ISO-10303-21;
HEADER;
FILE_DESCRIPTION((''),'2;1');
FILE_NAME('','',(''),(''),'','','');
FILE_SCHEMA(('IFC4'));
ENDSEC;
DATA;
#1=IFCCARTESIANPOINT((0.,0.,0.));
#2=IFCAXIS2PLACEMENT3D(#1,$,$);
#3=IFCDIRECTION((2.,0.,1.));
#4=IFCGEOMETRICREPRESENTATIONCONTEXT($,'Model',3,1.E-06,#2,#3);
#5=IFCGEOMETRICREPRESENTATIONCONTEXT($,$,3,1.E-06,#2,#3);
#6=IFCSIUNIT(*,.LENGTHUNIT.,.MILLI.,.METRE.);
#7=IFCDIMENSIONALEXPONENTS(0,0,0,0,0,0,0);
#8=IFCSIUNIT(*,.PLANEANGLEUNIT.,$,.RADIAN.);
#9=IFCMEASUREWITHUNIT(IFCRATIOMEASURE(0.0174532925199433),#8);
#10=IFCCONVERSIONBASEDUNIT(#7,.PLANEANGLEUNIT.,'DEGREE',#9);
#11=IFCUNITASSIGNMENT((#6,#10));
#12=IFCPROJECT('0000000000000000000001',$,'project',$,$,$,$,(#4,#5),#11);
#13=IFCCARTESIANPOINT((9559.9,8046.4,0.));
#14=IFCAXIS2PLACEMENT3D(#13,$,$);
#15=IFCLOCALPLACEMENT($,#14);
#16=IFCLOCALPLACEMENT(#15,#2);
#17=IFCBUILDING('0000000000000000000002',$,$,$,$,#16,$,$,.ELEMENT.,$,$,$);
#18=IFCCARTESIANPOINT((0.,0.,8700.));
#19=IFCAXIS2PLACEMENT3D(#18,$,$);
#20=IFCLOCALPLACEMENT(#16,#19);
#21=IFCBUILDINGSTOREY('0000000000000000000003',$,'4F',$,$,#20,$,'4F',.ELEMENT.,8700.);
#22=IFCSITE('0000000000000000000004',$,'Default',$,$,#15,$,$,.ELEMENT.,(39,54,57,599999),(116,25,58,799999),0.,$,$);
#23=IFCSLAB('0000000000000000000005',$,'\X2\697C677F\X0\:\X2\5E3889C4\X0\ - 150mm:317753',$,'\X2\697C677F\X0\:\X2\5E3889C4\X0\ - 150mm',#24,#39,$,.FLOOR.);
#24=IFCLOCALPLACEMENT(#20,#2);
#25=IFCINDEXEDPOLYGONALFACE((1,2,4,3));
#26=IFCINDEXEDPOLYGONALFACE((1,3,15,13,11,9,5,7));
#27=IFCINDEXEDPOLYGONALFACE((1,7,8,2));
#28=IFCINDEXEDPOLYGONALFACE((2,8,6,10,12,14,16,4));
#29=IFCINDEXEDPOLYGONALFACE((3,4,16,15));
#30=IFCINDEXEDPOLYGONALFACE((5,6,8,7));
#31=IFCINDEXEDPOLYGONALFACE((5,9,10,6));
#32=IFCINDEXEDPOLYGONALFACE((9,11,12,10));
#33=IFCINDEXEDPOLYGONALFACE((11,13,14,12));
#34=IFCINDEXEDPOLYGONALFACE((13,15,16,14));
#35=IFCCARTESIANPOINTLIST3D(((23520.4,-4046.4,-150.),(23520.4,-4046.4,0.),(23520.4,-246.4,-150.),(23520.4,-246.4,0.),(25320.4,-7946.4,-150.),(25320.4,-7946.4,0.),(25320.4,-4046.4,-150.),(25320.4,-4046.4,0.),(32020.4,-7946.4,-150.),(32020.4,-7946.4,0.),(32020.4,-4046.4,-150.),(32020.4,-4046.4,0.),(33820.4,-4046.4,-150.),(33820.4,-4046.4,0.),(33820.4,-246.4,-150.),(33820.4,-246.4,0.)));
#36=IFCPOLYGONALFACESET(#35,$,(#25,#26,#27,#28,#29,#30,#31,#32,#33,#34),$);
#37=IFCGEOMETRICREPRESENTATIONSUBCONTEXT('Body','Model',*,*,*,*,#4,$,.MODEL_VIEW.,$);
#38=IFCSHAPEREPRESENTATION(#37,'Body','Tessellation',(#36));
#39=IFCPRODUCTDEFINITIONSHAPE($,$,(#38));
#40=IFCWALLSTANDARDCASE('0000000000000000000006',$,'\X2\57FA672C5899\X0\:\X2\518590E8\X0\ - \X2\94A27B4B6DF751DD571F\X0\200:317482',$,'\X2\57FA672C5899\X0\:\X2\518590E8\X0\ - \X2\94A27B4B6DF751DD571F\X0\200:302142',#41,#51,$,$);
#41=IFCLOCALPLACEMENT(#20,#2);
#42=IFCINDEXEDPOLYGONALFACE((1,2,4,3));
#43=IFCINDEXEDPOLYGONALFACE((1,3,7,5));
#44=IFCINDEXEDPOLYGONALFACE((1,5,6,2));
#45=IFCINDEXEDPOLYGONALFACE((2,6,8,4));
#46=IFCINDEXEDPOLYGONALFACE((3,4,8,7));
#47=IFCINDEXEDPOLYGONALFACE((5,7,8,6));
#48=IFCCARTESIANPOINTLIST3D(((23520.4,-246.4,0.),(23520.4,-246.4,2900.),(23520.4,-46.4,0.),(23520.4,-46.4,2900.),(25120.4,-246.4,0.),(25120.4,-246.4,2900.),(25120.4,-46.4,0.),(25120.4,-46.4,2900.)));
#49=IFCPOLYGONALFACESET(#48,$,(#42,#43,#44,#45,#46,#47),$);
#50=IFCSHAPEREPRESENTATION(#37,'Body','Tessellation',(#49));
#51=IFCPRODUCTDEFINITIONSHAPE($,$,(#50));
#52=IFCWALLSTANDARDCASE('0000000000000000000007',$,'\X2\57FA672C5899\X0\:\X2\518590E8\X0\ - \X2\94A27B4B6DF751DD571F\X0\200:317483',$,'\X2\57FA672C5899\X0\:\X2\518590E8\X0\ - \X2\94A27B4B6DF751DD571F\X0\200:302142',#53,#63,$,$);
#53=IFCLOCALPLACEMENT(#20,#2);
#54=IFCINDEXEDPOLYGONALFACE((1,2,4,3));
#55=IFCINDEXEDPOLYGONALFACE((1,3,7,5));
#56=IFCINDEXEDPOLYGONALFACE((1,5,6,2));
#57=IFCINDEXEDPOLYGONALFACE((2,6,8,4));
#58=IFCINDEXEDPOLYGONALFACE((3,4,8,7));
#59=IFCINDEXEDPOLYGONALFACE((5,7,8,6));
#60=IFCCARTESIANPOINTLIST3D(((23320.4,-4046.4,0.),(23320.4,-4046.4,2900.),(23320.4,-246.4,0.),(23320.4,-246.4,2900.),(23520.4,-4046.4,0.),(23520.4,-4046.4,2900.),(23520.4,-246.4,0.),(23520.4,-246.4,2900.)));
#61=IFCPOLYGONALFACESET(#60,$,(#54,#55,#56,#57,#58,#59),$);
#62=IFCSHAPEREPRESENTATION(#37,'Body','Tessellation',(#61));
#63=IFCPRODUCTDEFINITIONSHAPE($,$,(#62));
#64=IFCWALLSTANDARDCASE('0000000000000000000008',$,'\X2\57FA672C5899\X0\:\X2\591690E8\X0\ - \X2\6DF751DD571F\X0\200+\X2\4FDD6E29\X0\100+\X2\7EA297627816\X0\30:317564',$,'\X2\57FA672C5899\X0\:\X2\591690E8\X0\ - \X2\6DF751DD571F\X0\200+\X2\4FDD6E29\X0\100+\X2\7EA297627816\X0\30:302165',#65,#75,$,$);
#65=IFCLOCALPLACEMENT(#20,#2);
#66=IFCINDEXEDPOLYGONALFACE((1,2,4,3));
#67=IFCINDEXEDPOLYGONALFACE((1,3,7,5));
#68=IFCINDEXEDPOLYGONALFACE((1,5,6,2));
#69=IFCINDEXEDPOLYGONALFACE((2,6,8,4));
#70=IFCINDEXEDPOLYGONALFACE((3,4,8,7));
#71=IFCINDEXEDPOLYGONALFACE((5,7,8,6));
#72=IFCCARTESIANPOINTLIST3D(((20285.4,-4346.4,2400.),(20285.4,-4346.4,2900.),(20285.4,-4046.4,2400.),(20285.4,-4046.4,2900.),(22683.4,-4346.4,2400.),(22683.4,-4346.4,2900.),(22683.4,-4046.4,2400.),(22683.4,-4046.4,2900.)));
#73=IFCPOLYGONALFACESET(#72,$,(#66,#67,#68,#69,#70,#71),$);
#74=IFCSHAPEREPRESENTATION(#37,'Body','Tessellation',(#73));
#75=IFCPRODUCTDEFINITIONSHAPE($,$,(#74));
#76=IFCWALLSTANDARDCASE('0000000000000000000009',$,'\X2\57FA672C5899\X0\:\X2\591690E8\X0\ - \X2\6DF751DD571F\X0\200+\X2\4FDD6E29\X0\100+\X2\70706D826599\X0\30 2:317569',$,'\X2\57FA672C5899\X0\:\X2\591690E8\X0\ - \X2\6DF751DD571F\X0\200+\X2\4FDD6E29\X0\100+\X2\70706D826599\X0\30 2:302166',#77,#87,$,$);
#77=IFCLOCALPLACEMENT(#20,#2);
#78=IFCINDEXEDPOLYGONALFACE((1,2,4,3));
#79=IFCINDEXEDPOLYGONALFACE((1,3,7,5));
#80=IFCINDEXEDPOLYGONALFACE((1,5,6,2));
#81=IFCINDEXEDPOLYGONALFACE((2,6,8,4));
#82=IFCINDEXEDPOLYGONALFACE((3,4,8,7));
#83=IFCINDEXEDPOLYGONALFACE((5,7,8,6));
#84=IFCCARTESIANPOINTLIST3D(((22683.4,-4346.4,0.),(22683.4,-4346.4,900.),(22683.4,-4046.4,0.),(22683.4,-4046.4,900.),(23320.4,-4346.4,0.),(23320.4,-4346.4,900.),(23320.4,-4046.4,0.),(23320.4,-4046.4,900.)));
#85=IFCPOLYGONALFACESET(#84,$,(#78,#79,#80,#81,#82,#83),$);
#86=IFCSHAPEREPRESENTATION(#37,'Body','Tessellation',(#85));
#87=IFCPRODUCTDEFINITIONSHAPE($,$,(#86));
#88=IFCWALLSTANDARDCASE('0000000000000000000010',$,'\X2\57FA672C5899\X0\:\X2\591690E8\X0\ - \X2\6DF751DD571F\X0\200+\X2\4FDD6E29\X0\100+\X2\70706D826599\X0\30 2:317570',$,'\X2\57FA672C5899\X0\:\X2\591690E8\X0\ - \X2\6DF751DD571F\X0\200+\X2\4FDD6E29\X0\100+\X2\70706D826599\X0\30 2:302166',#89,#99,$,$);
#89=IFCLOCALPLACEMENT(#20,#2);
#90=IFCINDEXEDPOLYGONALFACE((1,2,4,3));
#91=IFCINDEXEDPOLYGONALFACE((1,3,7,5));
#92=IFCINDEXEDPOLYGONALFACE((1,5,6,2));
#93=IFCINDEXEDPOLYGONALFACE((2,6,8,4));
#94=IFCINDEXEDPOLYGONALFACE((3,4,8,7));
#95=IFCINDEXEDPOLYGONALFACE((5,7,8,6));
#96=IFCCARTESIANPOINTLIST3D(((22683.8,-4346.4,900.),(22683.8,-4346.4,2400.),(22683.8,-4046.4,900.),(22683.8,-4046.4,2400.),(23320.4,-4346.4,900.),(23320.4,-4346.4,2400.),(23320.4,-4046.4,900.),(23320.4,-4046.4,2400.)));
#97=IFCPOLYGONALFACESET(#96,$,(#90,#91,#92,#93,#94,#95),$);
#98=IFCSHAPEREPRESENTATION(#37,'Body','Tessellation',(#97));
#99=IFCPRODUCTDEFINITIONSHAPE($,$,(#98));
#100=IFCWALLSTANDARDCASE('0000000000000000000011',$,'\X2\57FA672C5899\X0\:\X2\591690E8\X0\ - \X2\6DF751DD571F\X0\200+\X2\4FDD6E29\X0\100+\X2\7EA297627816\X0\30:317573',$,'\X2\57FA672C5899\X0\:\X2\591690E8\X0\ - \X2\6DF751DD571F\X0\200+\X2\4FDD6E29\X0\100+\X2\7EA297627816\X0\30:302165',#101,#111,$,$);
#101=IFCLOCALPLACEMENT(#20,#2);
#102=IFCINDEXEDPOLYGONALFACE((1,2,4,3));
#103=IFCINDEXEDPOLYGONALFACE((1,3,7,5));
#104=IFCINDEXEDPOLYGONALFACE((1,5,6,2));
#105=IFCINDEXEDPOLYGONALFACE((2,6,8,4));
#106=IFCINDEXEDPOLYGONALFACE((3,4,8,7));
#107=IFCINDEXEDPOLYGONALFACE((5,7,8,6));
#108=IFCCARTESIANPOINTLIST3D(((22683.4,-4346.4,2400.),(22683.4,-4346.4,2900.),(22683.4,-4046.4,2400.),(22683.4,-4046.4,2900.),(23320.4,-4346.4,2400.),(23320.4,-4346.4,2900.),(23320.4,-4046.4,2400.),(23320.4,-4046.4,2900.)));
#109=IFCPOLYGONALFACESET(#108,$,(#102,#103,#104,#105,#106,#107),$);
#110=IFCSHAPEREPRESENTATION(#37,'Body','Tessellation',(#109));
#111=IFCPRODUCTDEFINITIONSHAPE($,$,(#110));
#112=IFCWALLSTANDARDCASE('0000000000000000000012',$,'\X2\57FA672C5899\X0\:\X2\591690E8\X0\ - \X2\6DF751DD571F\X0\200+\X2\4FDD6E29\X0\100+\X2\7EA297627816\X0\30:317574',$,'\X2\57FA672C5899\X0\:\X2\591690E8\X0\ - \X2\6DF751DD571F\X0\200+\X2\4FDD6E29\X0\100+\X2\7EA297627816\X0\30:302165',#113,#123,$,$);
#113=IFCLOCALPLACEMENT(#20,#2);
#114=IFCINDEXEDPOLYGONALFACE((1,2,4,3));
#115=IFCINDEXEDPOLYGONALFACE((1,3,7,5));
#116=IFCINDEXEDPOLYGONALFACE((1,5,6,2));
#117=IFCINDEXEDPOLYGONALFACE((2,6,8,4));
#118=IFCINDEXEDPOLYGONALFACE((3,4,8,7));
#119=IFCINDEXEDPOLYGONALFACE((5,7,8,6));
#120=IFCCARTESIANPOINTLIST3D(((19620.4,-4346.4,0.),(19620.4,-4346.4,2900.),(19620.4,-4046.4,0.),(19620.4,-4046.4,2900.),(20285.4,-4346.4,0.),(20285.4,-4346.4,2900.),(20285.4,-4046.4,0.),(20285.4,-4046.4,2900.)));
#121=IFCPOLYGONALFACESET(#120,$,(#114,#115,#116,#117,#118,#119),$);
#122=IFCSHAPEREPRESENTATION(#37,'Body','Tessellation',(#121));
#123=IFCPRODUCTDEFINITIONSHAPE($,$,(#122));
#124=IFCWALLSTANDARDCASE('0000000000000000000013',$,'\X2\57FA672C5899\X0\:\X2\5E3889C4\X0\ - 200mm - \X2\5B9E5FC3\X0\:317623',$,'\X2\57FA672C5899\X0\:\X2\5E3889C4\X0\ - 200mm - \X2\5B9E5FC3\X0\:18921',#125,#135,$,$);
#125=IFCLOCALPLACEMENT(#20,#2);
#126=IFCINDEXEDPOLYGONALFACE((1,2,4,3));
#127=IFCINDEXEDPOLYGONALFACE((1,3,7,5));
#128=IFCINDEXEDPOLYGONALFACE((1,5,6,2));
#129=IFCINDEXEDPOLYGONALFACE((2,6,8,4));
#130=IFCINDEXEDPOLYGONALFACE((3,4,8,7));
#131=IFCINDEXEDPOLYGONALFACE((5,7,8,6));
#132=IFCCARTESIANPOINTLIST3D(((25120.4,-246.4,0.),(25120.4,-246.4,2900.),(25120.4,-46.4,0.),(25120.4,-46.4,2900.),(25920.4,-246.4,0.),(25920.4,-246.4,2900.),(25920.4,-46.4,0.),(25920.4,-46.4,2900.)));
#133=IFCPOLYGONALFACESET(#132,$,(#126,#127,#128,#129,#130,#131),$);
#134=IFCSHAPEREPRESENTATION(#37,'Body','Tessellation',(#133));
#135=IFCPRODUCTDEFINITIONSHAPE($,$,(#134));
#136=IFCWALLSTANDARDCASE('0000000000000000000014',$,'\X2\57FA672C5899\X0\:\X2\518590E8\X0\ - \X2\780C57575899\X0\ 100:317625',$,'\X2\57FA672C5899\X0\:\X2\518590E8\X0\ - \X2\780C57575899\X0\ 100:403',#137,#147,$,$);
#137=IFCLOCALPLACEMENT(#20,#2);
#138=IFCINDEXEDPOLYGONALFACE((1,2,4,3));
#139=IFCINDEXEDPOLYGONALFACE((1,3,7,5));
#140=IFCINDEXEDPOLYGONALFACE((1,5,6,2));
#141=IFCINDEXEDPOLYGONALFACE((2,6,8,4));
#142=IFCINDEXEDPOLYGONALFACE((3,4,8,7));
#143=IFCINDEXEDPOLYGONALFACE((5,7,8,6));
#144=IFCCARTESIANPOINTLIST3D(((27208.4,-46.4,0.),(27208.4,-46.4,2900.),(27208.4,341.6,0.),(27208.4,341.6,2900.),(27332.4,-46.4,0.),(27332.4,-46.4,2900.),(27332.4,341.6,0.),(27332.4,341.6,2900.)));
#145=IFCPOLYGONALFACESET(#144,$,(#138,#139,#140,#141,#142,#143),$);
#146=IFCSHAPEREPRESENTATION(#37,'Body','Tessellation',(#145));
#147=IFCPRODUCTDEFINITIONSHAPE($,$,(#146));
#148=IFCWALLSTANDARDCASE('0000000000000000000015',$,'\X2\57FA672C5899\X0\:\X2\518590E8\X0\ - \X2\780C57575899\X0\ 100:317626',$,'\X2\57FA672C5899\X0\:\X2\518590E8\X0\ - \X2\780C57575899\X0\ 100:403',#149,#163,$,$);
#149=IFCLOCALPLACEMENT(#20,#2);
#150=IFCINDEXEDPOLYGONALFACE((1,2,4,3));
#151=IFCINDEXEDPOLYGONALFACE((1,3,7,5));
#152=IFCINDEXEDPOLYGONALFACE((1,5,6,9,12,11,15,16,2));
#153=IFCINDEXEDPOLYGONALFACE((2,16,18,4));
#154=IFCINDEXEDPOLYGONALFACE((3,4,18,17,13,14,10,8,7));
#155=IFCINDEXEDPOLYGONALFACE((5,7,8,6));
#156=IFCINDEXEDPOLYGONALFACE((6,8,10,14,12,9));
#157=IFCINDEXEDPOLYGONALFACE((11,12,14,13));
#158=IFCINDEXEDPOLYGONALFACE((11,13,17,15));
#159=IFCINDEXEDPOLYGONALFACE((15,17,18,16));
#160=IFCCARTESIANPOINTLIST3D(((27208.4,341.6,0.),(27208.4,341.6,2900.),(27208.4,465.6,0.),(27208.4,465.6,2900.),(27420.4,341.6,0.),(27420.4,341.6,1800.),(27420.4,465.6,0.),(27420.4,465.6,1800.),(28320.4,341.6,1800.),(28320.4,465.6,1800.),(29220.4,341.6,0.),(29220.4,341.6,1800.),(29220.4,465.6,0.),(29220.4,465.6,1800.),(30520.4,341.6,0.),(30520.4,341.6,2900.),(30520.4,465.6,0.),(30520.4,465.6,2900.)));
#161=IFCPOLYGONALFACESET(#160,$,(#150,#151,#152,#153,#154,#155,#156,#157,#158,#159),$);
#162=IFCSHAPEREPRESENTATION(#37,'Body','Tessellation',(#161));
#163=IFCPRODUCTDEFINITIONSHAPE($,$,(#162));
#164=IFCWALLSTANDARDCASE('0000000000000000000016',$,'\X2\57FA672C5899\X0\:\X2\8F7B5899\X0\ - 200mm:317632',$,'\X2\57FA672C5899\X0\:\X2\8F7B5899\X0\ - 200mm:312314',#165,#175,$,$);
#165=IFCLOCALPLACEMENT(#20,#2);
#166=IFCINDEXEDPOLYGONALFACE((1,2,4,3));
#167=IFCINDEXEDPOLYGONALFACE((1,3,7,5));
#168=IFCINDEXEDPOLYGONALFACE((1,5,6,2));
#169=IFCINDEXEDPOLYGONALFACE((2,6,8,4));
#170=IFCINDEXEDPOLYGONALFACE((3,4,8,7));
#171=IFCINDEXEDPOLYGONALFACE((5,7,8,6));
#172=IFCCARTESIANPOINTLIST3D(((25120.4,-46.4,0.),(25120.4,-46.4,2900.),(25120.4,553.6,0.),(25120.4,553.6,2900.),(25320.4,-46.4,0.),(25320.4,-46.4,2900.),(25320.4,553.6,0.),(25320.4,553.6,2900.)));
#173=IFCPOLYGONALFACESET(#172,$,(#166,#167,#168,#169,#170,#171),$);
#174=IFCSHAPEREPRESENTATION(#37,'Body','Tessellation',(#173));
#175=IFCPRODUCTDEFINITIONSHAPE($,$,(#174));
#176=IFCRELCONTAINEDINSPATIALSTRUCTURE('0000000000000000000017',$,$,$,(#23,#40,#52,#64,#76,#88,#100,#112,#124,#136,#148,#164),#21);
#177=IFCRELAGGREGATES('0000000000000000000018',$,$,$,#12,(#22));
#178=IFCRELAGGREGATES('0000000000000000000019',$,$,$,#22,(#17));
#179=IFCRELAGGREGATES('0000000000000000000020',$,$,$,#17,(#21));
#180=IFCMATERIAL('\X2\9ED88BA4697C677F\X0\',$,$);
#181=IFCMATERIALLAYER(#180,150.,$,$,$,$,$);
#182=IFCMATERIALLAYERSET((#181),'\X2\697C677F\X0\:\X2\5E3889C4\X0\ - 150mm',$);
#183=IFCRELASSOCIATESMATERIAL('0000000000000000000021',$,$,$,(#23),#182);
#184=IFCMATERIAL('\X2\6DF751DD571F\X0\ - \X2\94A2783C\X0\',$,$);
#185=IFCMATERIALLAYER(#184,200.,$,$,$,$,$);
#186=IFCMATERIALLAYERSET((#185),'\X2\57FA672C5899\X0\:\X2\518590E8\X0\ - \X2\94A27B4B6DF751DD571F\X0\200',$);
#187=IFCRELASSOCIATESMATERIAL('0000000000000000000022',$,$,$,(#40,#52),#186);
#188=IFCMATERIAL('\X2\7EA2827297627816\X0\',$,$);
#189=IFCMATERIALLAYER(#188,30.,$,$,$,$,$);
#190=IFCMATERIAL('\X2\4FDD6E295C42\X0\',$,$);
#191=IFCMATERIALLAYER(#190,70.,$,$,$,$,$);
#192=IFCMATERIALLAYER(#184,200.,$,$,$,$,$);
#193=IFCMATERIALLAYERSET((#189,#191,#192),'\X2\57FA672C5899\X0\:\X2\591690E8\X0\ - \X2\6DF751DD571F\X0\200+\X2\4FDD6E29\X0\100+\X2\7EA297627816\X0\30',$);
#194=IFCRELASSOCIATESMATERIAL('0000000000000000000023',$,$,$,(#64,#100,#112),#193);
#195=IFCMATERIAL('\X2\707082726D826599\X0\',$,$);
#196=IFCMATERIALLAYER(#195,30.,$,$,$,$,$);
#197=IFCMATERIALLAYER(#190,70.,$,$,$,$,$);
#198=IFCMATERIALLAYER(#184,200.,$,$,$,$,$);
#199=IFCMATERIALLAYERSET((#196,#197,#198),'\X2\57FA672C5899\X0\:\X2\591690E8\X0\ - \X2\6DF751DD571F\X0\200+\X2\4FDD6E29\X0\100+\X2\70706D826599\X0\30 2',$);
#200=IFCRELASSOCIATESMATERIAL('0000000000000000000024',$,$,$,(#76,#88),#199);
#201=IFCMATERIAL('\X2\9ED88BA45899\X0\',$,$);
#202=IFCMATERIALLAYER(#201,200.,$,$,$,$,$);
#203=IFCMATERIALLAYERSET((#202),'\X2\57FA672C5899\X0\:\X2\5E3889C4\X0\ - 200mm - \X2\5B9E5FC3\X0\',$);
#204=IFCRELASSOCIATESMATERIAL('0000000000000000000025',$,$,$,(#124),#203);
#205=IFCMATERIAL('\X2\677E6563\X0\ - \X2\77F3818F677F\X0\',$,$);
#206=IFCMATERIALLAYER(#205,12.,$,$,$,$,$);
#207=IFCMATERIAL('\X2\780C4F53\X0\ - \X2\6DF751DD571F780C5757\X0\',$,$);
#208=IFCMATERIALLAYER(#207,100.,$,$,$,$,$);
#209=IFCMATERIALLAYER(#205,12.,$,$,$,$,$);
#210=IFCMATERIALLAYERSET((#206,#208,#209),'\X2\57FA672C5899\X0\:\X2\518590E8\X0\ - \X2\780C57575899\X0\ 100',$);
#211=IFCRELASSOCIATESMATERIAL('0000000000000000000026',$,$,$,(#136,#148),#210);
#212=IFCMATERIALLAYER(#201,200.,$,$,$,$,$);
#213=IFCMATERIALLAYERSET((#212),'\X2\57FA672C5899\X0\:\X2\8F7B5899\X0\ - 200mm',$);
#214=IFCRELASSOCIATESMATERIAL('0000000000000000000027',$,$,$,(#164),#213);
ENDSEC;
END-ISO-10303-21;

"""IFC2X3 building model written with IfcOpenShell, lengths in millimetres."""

from ifc_helpers import new_model, entity, si_unit, converted_unit, direction, frame, frame_2d, origin, place, context, subcontext, project, spatial, polyline, rectangle, outline, extrude, material, layer, layer_set, layer_usage, element, save


model = new_model("IFC2X3")

# Units and contexts
model_context = context("Model", 3, precision=1e-06, world=origin(), true_north=direction((2.0, 0.0, 1.0)))
context_of_model = context(None, 3, precision=1e-06, world=origin(), true_north=direction((2.0, 0.0, 1.0)))
body_context = subcontext(model_context, "Body", "Model", "MODEL_VIEW")
ifc_project = project(units=[si_unit("LENGTHUNIT", "METRE", prefix="MILLI"), converted_unit("PLANEANGLEUNIT", "DEGREE", entity("IfcRatioMeasure", 0.0174532925199433), si_unit("PLANEANGLEUNIT", "RADIAN"), dimensions=[0, 0, 0, 0, 0, 0, 0])], contexts=[model_context, context_of_model])

# Site, building, storey
site_placement = place(None, frame((9559.9, 8046.4, 0.0)))
site = spatial("IfcSite", under=ifc_project, at=site_placement, Name="Default", CompositionType="ELEMENT", RefLatitude=(39, 54, 57, 599999), RefLongitude=(116, 25, 58, 799999), RefElevation=0.0)
building_placement = place(site_placement, origin())
building = spatial("IfcBuilding", under=site, at=building_placement, CompositionType="ELEMENT")
storey_placement = place(building_placement, frame((0.0, 0.0, 8700.0)))
storey = spatial("IfcBuildingStorey", under=building, at=storey_placement, Name="4F", LongName="4F", CompositionType="ELEMENT", Elevation=8700.0)

# Slab
ifc_material_1 = material(Name="默认楼板")
ifc_layer_1 = layer(ifc_material_1, 150.0)
ifc_layer_set_1 = layer_set([ifc_layer_1], Name="楼板:常规 - 150mm")
ifc_layer_usage_1 = layer_usage(ifc_layer_set_1, "AXIS3", "POSITIVE", 0.0)
slab_placement = place(storey_placement, frame((23520.4, -7946.4, -150.0)))
element("IfcSlab", 1, at=slab_placement, inside=storey, material=ifc_layer_usage_1, Name="楼板:常规 - 150mm:317753", ObjectType="楼板:常规 - 150mm", PredefinedType="FLOOR", context=body_context, shape_type="SweptSolid", body=[
    extrude(outline(polyline([(-5150.0, 50.0), (-3350.0, 50.0), (-3350.0, -3850.0), (3350.0, -3850.0), (3350.0, 50.0), (5150.0, 50.0), (5150.0, 3850.0), (-5150.0, 3850.0), (-5150.0, 50.0)])), frame((5150.0, 3850.0, 150.0), z_axis=(0.0, 0.0, -1.0), x_axis=(-1.0, 0.0, 0.0)), (0.0, 0.0, 1.0), 150.0),
])

# Walls
ifc_material_2 = material(Name="混凝土 - 钢砼")
ifc_layer_2 = layer(ifc_material_2, 200.0)
ifc_layer_set_2 = layer_set([ifc_layer_2], Name="基本墙:内部 - 钢筋混凝土200")
ifc_layer_usage_2 = layer_usage(ifc_layer_set_2, "AXIS2", "NEGATIVE", 100.0)
wall_1_placement = place(storey_placement, frame((25120.4, -146.4, 0.0), z_axis=(0.0, 0.0, 1.0), x_axis=(-1.0, 0.0, 0.0)))
element("IfcWallStandardCase", 2, at=wall_1_placement, inside=storey, material=ifc_layer_usage_2, Name="基本墙:内部 - 钢筋混凝土200:317482", ObjectType="基本墙:内部 - 钢筋混凝土200:302142", context=body_context, shape_type="SweptSolid", body=[
    extrude(rectangle(XDim=1600.0, YDim=200.0, at=frame_2d((800.0, 0.0), x_axis=(-1.0, 0.0))), origin(), (0.0, 0.0, 1.0), 2900.0),
])
ifc_layer_usage_3 = layer_usage(ifc_layer_set_2, "AXIS2", "NEGATIVE", 100.0)
wall_2_placement = place(storey_placement, frame((23420.4, -4046.4, 0.0), z_axis=(0.0, 0.0, 1.0), x_axis=(0.0, 1.0, 0.0)))
element("IfcWallStandardCase", 3, at=wall_2_placement, inside=storey, material=ifc_layer_usage_3, Name="基本墙:内部 - 钢筋混凝土200:317483", ObjectType="基本墙:内部 - 钢筋混凝土200:302142", context=body_context, shape_type="SweptSolid", body=[
    extrude(rectangle(XDim=3800.0, YDim=200.0, at=frame_2d((1900.0, 0.0), x_axis=(-1.0, 0.0))), origin(), (0.0, 0.0, 1.0), 2900.0),
])
ifc_material_3 = material(Name="红色面砖")
ifc_layer_3 = layer(ifc_material_3, 30.0)
ifc_material_4 = material(Name="保温层")
ifc_layer_4 = layer(ifc_material_4, 70.0)
ifc_layer_5 = layer(ifc_material_2, 200.0)
ifc_layer_set_3 = layer_set([ifc_layer_3, ifc_layer_4, ifc_layer_5], Name="基本墙:外部 - 混凝土200+保温100+红面砖30")
ifc_layer_usage_4 = layer_usage(ifc_layer_set_3, "AXIS2", "POSITIVE", -150.0)
wall_3_placement = place(storey_placement, frame((20285.4, -4196.4, 2400.0)))
element("IfcWallStandardCase", 4, at=wall_3_placement, inside=storey, material=ifc_layer_usage_4, Name="基本墙:外部 - 混凝土200+保温100+红面砖30:317564", ObjectType="基本墙:外部 - 混凝土200+保温100+红面砖30:302165", context=body_context, shape_type="SweptSolid", body=[
    extrude(rectangle(XDim=2398.1, YDim=300.0, at=frame_2d((1199.0, 0.0), x_axis=(-1.0, 0.0))), origin(), (0.0, 0.0, 1.0), 500.0),
])

# Walls
ifc_material_5 = material(Name="灰色涂料")
ifc_layer_6 = layer(ifc_material_5, 30.0)
ifc_layer_7 = layer(ifc_material_4, 70.0)
ifc_layer_8 = layer(ifc_material_2, 200.0)
ifc_layer_set_4 = layer_set([ifc_layer_6, ifc_layer_7, ifc_layer_8], Name="基本墙:外部 - 混凝土200+保温100+灰涂料30 2")
ifc_layer_usage_5 = layer_usage(ifc_layer_set_4, "AXIS2", "POSITIVE", -150.0)
wall_4_placement = place(storey_placement, frame((22683.4, -4196.4, 0.0)))
element("IfcWallStandardCase", 5, at=wall_4_placement, inside=storey, material=ifc_layer_usage_5, Name="基本墙:外部 - 混凝土200+保温100+灰涂料30 2:317569", ObjectType="基本墙:外部 - 混凝土200+保温100+灰涂料30 2:302166", context=body_context, shape_type="SweptSolid", body=[
    extrude(rectangle(XDim=636.9, YDim=300.0, at=frame_2d((318.5, 0.0), x_axis=(-1.0, 0.0))), origin(), (0.0, 0.0, 1.0), 900.0),
])
ifc_layer_usage_6 = layer_usage(ifc_layer_set_4, "AXIS2", "POSITIVE", -150.0)
wall_5_placement = place(storey_placement, frame((22683.8, -4196.4, 900.0)))
element("IfcWallStandardCase", 6, at=wall_5_placement, inside=storey, material=ifc_layer_usage_6, Name="基本墙:外部 - 混凝土200+保温100+灰涂料30 2:317570", ObjectType="基本墙:外部 - 混凝土200+保温100+灰涂料30 2:302166", context=body_context, shape_type="SweptSolid", body=[
    extrude(rectangle(XDim=636.6, YDim=300.0, at=frame_2d((318.3, 0.0), x_axis=(-1.0, 0.0))), origin(), (0.0, 0.0, 1.0), 1500.0),
])
ifc_layer_usage_7 = layer_usage(ifc_layer_set_3, "AXIS2", "POSITIVE", -150.0)
wall_6_placement = place(storey_placement, frame((22683.4, -4196.4, 2400.0)))
element("IfcWallStandardCase", 7, at=wall_6_placement, inside=storey, material=ifc_layer_usage_7, Name="基本墙:外部 - 混凝土200+保温100+红面砖30:317573", ObjectType="基本墙:外部 - 混凝土200+保温100+红面砖30:302165", context=body_context, shape_type="SweptSolid", body=[
    extrude(rectangle(XDim=636.9, YDim=300.0, at=frame_2d((318.5, 0.0), x_axis=(-1.0, 0.0))), origin(), (0.0, 0.0, 1.0), 500.0),
])
ifc_layer_usage_8 = layer_usage(ifc_layer_set_3, "AXIS2", "POSITIVE", -150.0)
wall_7_placement = place(storey_placement, frame((19620.4, -4196.4, 0.0)))
element("IfcWallStandardCase", 8, at=wall_7_placement, inside=storey, material=ifc_layer_usage_8, Name="基本墙:外部 - 混凝土200+保温100+红面砖30:317574", ObjectType="基本墙:外部 - 混凝土200+保温100+红面砖30:302165", context=body_context, shape_type="SweptSolid", body=[
    extrude(rectangle(XDim=665.0, YDim=300.0, at=frame_2d((332.5, 0.0), x_axis=(-1.0, 0.0))), origin(), (0.0, 0.0, 1.0), 2900.0),
])
ifc_material_6 = material(Name="默认墙")
ifc_layer_9 = layer(ifc_material_6, 200.0)
ifc_layer_set_5 = layer_set([ifc_layer_9], Name="基本墙:常规 - 200mm - 实心")
ifc_layer_usage_9 = layer_usage(ifc_layer_set_5, "AXIS2", "POSITIVE", -100.0)
wall_8_placement = place(storey_placement, frame((25120.4, -146.4, 0.0)))
element("IfcWallStandardCase", 9, at=wall_8_placement, inside=storey, material=ifc_layer_usage_9, Name="基本墙:常规 - 200mm - 实心:317623", ObjectType="基本墙:常规 - 200mm - 实心:18921", context=body_context, shape_type="SweptSolid", body=[
    extrude(rectangle(XDim=800.0, YDim=200.0, at=frame_2d((400.0, 0.0), x_axis=(-1.0, 0.0))), origin(), (0.0, 0.0, 1.0), 2900.0),
])
ifc_material_7 = material(Name="松散 - 石膏板")
ifc_layer_10 = layer(ifc_material_7, 12.0)
ifc_material_8 = material(Name="砌体 - 混凝土砌块")
ifc_layer_11 = layer(ifc_material_8, 100.0)
ifc_layer_12 = layer(ifc_material_7, 12.0)
ifc_layer_set_6 = layer_set([ifc_layer_10, ifc_layer_11, ifc_layer_12], Name="基本墙:内部 - 砌块墙 100")
ifc_layer_usage_10 = layer_usage(ifc_layer_set_6, "AXIS2", "POSITIVE", -62.0)
wall_9_placement = place(storey_placement, frame((27270.4, -46.4, 0.0), z_axis=(0.0, 0.0, 1.0), x_axis=(0.0, 1.0, 0.0)))
element("IfcWallStandardCase", 10, at=wall_9_placement, inside=storey, material=ifc_layer_usage_10, Name="基本墙:内部 - 砌块墙 100:317625", ObjectType="基本墙:内部 - 砌块墙 100:403", context=body_context, shape_type="SweptSolid", body=[
    extrude(rectangle(XDim=388.0, YDim=124.0, at=frame_2d((194.0, 0.0), x_axis=(-1.0, 0.0))), origin(), (0.0, 0.0, 1.0), 2900.0),
])

# Wall, openings
ifc_layer_usage_11 = layer_usage(ifc_layer_set_6, "AXIS2", "POSITIVE", -62.0)
wall_10_placement = place(storey_placement, frame((27208.4, 403.6, 0.0)))
wall_10 = element("IfcWallStandardCase", 11, at=wall_10_placement, inside=storey, material=ifc_layer_usage_11, Name="基本墙:内部 - 砌块墙 100:317626", ObjectType="基本墙:内部 - 砌块墙 100:403", context=body_context, shape_type="SweptSolid", body=[
    extrude(rectangle(XDim=3312.0, YDim=124.0, at=frame_2d((1656.0, 0.0), x_axis=(-1.0, 0.0))), origin(), (0.0, 0.0, 1.0), 2900.0),
])
opening_1_placement = place(wall_10_placement, frame((1112.0, -62.0, 0.0)))
element("IfcOpeningElement", 12, at=opening_1_placement, cuts=wall_10, ObjectType="Opening", context=body_context, shape_type="SweptSolid", body=[
    extrude(rectangle(XDim=1800.0, YDim=900.0, at=frame_2d((900.0, 450.0), x_axis=(1.0, 0.0))), frame((0.0, 0.0, 0.0), z_axis=(0.0, 1.0, 0.0), x_axis=(0.0, 0.0, 1.0)), (0.0, 0.0, 1.0), 124.0),
])
opening_2_placement = place(wall_10_placement, frame((212.0, -62.0, 0.0)))
element("IfcOpeningElement", 13, at=opening_2_placement, cuts=wall_10, ObjectType="Opening", context=body_context, shape_type="SweptSolid", body=[
    extrude(rectangle(XDim=1800.0, YDim=900.0, at=frame_2d((900.0, 450.0), x_axis=(1.0, 0.0))), frame((0.0, 0.0, 0.0), z_axis=(0.0, 1.0, 0.0), x_axis=(0.0, 0.0, 1.0)), (0.0, 0.0, 1.0), 124.0),
])

# Wall
ifc_layer_13 = layer(ifc_material_6, 200.0)
ifc_layer_set_7 = layer_set([ifc_layer_13], Name="基本墙:轻墙 - 200mm")
ifc_layer_usage_12 = layer_usage(ifc_layer_set_7, "AXIS2", "POSITIVE", -100.0)
wall_11_placement = place(storey_placement, frame((25220.4, -46.4, 0.0), z_axis=(0.0, 0.0, 1.0), x_axis=(0.0, 1.0, 0.0)))
element("IfcWallStandardCase", 14, at=wall_11_placement, inside=storey, material=ifc_layer_usage_12, Name="基本墙:轻墙 - 200mm:317632", ObjectType="基本墙:轻墙 - 200mm:312314", context=body_context, shape_type="SweptSolid", body=[
    extrude(rectangle(XDim=600.0, YDim=200.0, at=frame_2d((300.0, 0.0), x_axis=(-1.0, 0.0))), origin(), (0.0, 0.0, 1.0), 2900.0),
])

save(model, "model.ifc")
